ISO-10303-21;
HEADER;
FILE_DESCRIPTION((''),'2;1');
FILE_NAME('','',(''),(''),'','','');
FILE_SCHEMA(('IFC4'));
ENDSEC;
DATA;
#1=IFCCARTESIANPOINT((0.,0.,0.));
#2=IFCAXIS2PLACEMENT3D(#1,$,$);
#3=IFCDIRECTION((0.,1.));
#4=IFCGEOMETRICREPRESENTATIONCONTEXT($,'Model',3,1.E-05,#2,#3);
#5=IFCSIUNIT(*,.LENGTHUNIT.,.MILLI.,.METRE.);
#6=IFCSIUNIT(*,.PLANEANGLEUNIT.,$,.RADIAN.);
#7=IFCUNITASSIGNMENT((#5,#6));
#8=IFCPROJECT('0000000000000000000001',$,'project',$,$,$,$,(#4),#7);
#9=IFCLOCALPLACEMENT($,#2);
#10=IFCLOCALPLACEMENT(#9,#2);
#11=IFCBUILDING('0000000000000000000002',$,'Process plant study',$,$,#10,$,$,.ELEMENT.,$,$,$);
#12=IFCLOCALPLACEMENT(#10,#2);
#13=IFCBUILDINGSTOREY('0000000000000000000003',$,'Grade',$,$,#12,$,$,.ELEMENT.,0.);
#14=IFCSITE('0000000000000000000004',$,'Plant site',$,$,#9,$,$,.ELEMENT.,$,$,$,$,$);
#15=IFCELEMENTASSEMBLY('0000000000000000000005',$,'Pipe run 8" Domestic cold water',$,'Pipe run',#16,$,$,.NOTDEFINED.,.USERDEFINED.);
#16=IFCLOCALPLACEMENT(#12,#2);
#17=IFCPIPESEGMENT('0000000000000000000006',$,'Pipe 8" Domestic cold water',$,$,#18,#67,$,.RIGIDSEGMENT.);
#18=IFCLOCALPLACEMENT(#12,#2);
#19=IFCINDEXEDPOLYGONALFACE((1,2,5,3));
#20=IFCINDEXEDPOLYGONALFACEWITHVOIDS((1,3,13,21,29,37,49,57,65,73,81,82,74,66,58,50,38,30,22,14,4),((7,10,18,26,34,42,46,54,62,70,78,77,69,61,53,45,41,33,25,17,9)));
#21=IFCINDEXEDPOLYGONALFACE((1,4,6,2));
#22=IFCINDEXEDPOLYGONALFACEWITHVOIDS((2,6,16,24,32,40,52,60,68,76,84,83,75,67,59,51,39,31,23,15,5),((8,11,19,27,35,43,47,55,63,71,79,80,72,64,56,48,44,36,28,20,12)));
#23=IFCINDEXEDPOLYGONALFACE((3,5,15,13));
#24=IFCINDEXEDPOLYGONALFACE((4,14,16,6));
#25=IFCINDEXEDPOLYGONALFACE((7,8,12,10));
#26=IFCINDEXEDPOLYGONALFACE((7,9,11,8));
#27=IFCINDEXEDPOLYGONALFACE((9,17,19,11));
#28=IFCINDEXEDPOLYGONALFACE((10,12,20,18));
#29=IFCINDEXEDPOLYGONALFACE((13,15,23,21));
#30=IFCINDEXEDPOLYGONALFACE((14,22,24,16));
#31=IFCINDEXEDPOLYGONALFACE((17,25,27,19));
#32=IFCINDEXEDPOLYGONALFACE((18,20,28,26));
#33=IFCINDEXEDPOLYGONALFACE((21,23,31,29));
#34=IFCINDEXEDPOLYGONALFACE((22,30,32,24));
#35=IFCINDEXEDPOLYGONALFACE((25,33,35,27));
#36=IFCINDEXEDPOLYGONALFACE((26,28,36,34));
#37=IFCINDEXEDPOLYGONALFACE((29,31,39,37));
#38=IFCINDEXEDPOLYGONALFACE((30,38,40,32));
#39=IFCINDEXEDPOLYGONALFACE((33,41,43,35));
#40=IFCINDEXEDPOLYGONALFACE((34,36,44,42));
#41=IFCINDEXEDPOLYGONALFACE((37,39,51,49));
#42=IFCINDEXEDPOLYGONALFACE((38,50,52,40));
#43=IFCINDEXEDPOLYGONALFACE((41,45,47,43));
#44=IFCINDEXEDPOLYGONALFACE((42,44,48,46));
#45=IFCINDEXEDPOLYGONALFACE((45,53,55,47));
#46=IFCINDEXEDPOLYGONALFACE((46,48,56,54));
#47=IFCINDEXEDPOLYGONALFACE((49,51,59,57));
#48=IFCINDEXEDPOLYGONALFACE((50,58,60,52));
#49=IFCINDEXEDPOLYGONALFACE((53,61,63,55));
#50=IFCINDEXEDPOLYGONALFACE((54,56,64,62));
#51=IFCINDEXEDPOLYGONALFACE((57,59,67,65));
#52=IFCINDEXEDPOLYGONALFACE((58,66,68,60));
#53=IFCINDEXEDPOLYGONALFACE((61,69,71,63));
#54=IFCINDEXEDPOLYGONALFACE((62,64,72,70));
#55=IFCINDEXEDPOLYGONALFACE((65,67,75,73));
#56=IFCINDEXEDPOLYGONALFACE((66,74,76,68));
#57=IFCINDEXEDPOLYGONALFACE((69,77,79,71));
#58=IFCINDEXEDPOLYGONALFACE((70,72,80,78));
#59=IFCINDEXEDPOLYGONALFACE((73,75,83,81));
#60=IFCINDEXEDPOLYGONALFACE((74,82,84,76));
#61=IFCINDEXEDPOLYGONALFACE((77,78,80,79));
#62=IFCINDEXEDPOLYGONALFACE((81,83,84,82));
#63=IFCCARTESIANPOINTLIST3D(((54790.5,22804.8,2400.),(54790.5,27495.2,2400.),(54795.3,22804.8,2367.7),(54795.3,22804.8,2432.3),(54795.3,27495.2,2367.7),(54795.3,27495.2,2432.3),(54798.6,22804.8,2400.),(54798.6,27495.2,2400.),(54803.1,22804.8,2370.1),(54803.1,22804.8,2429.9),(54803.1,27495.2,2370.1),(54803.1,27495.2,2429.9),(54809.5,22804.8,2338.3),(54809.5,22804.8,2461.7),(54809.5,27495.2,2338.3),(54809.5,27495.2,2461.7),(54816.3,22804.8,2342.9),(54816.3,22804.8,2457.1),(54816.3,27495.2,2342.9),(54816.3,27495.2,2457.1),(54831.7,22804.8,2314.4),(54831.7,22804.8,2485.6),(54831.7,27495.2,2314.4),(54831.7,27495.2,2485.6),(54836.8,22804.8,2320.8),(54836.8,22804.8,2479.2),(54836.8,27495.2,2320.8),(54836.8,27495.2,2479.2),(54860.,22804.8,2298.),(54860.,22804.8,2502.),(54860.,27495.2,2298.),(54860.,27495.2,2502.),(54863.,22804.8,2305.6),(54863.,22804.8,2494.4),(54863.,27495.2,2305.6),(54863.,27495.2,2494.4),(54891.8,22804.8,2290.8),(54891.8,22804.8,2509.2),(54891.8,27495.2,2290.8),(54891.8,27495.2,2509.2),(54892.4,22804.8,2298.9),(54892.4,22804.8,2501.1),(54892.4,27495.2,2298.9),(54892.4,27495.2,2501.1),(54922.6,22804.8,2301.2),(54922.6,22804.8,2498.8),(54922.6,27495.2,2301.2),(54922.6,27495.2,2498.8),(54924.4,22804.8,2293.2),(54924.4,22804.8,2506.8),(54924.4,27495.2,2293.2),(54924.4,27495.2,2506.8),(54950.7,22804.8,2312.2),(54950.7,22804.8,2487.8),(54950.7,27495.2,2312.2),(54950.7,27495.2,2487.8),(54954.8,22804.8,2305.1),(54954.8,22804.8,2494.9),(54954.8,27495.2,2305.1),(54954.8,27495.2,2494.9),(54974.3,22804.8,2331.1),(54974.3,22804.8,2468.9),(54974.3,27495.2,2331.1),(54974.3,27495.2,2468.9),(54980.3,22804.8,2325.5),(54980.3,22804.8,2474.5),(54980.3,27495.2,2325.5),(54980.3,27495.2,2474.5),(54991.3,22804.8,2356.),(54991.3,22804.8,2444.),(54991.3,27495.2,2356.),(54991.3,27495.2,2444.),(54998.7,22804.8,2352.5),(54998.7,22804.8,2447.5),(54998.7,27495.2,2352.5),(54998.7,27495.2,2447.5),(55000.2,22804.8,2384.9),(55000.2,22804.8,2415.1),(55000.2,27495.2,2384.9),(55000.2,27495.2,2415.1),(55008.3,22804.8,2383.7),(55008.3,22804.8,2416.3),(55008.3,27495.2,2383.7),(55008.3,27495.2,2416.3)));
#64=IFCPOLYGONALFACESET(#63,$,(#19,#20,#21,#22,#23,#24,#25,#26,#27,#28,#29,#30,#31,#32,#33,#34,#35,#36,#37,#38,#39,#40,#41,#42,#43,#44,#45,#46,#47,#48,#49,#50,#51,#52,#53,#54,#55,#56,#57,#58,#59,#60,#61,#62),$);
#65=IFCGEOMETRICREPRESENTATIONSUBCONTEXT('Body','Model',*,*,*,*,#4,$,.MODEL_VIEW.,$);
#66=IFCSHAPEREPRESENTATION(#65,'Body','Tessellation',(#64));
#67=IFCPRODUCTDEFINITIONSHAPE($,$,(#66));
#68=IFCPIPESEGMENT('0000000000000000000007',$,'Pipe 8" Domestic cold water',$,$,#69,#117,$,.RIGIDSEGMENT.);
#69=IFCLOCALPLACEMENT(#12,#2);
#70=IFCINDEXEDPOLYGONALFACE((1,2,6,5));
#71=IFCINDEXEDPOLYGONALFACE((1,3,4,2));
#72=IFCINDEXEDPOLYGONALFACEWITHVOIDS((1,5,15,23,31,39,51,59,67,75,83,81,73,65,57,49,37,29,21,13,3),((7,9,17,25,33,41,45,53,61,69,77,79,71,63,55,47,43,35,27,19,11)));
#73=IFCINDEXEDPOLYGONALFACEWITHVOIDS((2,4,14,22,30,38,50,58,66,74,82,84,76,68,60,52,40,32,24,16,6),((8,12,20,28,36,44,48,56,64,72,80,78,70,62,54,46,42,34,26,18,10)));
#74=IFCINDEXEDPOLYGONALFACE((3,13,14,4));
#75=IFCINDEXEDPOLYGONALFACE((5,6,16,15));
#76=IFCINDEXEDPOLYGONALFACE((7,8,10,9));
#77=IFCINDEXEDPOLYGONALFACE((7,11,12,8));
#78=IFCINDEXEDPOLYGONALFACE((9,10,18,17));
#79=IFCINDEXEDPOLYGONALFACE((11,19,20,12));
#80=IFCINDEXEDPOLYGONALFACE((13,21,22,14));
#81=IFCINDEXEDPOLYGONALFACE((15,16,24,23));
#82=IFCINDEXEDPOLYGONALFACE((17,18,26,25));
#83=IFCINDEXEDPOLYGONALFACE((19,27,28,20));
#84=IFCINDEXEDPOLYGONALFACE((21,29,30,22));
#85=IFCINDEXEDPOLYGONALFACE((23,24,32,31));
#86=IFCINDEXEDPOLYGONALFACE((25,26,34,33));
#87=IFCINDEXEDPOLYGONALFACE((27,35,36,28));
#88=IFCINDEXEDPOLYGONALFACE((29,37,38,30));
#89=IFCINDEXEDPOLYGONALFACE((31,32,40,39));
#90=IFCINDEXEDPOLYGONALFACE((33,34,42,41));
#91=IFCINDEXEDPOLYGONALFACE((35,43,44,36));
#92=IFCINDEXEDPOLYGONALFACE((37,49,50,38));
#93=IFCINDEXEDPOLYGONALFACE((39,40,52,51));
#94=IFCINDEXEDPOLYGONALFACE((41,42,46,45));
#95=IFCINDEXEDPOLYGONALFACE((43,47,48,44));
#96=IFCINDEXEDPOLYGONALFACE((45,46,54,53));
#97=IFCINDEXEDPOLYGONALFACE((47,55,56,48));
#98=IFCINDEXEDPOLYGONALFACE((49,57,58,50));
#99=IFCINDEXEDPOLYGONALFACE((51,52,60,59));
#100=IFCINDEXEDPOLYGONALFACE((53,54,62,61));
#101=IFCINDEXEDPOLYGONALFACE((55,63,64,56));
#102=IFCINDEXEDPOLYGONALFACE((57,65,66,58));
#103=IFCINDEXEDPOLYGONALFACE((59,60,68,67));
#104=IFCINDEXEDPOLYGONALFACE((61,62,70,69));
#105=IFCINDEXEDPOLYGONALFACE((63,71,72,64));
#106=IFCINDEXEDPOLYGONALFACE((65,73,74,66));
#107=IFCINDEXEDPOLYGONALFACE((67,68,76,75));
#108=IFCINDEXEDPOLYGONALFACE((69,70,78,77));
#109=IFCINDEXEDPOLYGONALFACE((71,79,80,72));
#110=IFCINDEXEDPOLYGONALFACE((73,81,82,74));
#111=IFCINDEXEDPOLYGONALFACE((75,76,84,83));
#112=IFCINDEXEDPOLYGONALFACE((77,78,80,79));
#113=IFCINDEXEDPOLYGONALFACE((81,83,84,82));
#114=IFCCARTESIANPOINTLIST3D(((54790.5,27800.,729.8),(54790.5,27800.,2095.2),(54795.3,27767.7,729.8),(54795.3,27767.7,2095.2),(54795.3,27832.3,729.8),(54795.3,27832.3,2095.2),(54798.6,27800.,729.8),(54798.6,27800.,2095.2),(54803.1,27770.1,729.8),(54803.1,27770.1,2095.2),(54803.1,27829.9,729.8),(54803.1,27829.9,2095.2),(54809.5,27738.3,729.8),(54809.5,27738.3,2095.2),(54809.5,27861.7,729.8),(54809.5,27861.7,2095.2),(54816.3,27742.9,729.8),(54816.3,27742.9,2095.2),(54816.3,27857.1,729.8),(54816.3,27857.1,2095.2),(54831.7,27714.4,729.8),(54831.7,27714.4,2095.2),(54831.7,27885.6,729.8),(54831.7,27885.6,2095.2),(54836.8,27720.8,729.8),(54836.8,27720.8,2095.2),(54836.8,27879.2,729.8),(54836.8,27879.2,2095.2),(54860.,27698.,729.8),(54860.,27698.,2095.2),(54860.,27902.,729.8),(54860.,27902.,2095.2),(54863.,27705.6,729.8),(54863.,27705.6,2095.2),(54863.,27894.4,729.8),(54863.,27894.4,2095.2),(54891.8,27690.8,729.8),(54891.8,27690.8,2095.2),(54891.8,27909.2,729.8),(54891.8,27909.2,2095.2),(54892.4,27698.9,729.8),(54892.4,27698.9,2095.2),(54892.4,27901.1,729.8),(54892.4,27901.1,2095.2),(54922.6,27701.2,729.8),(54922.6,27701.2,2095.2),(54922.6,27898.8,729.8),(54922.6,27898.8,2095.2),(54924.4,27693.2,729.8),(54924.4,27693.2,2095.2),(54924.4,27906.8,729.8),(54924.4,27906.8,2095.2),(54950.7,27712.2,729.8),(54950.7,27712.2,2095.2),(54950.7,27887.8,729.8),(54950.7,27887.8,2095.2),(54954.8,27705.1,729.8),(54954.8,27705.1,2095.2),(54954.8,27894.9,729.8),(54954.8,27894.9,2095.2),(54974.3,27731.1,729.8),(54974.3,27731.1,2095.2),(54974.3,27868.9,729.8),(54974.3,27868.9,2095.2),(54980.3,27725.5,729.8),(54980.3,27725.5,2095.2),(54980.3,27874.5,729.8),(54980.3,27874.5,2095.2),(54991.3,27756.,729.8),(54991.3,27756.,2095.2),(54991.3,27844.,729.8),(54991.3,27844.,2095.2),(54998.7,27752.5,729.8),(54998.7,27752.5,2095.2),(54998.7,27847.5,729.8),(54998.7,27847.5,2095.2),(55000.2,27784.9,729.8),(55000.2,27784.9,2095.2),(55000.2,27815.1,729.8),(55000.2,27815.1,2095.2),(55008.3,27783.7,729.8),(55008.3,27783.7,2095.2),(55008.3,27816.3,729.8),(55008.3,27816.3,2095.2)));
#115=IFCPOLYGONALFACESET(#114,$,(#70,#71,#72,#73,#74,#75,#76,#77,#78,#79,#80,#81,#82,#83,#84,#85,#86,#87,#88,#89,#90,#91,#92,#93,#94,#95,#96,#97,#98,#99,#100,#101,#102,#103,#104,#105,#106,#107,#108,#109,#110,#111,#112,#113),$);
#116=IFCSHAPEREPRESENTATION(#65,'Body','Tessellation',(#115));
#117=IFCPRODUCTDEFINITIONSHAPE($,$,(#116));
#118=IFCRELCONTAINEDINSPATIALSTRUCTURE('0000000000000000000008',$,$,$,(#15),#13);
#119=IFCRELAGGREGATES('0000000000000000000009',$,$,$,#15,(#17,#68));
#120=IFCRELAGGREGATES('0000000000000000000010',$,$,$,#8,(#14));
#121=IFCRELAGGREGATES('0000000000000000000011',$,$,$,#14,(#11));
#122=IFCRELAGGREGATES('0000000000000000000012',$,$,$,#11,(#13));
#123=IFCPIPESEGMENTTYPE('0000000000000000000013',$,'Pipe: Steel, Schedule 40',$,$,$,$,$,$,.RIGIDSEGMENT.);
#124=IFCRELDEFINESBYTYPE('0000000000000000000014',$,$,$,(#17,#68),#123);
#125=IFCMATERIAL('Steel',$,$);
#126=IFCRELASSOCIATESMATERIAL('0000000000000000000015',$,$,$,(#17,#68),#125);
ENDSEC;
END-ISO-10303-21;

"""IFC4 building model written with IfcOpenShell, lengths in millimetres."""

from ifc_helpers import new_model, si_unit, direction, frame, origin, origin_with_axes, origin_2d, place, context, subcontext, project, spatial, hollow_circle, extrude, material, type_object, element, aggregate, save


model = new_model("IFC4")

# Units and contexts
model_context = context("Model", 3, precision=1e-05, world=origin(), true_north=direction((0.0, 1.0)))
body_context = subcontext(model_context, "Body", "Model", "MODEL_VIEW")
ifc_project = project(units=[si_unit("LENGTHUNIT", "METRE", prefix="MILLI"), si_unit("PLANEANGLEUNIT", "RADIAN")], contexts=[model_context])

# Site, building, storey
site_placement = place(None, origin())
site = spatial("IfcSite", under=ifc_project, at=site_placement, Name="Plant site", CompositionType="ELEMENT")
building_placement = place(site_placement, origin())
building = spatial("IfcBuilding", under=site, at=building_placement, Name="Process plant study", CompositionType="ELEMENT")
storey_placement = place(building_placement, origin())
storey = spatial("IfcBuildingStorey", under=building, at=storey_placement, Name="Grade", CompositionType="ELEMENT", Elevation=0.0)

# Element assembly, pipe segments
ifc_material = material(Name="Steel")
pipe_segment_type = type_object("IfcPipeSegmentType", Name="Pipe: Steel, Schedule 40", PredefinedType="RIGIDSEGMENT")
assembly_1_placement = place(storey_placement, origin_with_axes())
assembly_1 = element("IfcElementAssembly", 1, at=assembly_1_placement, inside=storey, Name="Pipe run 8\" Domestic cold water", ObjectType="Pipe run", AssemblyPlace="NOTDEFINED", PredefinedType="USERDEFINED")
pipe_segment_1_placement = place(storey_placement, origin_with_axes())
pipe_segment_1 = element("IfcPipeSegment", 2, at=pipe_segment_1_placement, type_object=pipe_segment_type, material=ifc_material, Name="Pipe 8\" Domestic cold water", PredefinedType="RIGIDSEGMENT", context=body_context, shape_type="SweptSolid", body=[
    extrude(hollow_circle(Radius=109.5, WallThickness=8.2, at=origin_2d()), frame((54900.0, 22804.8, 2400.0), z_axis=(0.0, 1.0, 0.0), x_axis=(-1.0, 0.0, 0.0)), (0.0, 0.0, 1.0), 4690.4),
])
pipe_segment_2_placement = place(storey_placement, origin_with_axes())
pipe_segment_2 = element("IfcPipeSegment", 3, at=pipe_segment_2_placement, type_object=pipe_segment_type, material=ifc_material, Name="Pipe 8\" Domestic cold water", PredefinedType="RIGIDSEGMENT", context=body_context, shape_type="SweptSolid", body=[
    extrude(hollow_circle(Radius=109.5, WallThickness=8.2, at=origin_2d()), frame((54900.0, 27800.0, 2095.2), z_axis=(0.0, 0.0, -1.0), x_axis=(-1.0, 0.0, 0.0)), (0.0, 0.0, 1.0), 1365.4),
])

aggregate(assembly_1, [pipe_segment_1, pipe_segment_2])

save(model, "model.ifc")
